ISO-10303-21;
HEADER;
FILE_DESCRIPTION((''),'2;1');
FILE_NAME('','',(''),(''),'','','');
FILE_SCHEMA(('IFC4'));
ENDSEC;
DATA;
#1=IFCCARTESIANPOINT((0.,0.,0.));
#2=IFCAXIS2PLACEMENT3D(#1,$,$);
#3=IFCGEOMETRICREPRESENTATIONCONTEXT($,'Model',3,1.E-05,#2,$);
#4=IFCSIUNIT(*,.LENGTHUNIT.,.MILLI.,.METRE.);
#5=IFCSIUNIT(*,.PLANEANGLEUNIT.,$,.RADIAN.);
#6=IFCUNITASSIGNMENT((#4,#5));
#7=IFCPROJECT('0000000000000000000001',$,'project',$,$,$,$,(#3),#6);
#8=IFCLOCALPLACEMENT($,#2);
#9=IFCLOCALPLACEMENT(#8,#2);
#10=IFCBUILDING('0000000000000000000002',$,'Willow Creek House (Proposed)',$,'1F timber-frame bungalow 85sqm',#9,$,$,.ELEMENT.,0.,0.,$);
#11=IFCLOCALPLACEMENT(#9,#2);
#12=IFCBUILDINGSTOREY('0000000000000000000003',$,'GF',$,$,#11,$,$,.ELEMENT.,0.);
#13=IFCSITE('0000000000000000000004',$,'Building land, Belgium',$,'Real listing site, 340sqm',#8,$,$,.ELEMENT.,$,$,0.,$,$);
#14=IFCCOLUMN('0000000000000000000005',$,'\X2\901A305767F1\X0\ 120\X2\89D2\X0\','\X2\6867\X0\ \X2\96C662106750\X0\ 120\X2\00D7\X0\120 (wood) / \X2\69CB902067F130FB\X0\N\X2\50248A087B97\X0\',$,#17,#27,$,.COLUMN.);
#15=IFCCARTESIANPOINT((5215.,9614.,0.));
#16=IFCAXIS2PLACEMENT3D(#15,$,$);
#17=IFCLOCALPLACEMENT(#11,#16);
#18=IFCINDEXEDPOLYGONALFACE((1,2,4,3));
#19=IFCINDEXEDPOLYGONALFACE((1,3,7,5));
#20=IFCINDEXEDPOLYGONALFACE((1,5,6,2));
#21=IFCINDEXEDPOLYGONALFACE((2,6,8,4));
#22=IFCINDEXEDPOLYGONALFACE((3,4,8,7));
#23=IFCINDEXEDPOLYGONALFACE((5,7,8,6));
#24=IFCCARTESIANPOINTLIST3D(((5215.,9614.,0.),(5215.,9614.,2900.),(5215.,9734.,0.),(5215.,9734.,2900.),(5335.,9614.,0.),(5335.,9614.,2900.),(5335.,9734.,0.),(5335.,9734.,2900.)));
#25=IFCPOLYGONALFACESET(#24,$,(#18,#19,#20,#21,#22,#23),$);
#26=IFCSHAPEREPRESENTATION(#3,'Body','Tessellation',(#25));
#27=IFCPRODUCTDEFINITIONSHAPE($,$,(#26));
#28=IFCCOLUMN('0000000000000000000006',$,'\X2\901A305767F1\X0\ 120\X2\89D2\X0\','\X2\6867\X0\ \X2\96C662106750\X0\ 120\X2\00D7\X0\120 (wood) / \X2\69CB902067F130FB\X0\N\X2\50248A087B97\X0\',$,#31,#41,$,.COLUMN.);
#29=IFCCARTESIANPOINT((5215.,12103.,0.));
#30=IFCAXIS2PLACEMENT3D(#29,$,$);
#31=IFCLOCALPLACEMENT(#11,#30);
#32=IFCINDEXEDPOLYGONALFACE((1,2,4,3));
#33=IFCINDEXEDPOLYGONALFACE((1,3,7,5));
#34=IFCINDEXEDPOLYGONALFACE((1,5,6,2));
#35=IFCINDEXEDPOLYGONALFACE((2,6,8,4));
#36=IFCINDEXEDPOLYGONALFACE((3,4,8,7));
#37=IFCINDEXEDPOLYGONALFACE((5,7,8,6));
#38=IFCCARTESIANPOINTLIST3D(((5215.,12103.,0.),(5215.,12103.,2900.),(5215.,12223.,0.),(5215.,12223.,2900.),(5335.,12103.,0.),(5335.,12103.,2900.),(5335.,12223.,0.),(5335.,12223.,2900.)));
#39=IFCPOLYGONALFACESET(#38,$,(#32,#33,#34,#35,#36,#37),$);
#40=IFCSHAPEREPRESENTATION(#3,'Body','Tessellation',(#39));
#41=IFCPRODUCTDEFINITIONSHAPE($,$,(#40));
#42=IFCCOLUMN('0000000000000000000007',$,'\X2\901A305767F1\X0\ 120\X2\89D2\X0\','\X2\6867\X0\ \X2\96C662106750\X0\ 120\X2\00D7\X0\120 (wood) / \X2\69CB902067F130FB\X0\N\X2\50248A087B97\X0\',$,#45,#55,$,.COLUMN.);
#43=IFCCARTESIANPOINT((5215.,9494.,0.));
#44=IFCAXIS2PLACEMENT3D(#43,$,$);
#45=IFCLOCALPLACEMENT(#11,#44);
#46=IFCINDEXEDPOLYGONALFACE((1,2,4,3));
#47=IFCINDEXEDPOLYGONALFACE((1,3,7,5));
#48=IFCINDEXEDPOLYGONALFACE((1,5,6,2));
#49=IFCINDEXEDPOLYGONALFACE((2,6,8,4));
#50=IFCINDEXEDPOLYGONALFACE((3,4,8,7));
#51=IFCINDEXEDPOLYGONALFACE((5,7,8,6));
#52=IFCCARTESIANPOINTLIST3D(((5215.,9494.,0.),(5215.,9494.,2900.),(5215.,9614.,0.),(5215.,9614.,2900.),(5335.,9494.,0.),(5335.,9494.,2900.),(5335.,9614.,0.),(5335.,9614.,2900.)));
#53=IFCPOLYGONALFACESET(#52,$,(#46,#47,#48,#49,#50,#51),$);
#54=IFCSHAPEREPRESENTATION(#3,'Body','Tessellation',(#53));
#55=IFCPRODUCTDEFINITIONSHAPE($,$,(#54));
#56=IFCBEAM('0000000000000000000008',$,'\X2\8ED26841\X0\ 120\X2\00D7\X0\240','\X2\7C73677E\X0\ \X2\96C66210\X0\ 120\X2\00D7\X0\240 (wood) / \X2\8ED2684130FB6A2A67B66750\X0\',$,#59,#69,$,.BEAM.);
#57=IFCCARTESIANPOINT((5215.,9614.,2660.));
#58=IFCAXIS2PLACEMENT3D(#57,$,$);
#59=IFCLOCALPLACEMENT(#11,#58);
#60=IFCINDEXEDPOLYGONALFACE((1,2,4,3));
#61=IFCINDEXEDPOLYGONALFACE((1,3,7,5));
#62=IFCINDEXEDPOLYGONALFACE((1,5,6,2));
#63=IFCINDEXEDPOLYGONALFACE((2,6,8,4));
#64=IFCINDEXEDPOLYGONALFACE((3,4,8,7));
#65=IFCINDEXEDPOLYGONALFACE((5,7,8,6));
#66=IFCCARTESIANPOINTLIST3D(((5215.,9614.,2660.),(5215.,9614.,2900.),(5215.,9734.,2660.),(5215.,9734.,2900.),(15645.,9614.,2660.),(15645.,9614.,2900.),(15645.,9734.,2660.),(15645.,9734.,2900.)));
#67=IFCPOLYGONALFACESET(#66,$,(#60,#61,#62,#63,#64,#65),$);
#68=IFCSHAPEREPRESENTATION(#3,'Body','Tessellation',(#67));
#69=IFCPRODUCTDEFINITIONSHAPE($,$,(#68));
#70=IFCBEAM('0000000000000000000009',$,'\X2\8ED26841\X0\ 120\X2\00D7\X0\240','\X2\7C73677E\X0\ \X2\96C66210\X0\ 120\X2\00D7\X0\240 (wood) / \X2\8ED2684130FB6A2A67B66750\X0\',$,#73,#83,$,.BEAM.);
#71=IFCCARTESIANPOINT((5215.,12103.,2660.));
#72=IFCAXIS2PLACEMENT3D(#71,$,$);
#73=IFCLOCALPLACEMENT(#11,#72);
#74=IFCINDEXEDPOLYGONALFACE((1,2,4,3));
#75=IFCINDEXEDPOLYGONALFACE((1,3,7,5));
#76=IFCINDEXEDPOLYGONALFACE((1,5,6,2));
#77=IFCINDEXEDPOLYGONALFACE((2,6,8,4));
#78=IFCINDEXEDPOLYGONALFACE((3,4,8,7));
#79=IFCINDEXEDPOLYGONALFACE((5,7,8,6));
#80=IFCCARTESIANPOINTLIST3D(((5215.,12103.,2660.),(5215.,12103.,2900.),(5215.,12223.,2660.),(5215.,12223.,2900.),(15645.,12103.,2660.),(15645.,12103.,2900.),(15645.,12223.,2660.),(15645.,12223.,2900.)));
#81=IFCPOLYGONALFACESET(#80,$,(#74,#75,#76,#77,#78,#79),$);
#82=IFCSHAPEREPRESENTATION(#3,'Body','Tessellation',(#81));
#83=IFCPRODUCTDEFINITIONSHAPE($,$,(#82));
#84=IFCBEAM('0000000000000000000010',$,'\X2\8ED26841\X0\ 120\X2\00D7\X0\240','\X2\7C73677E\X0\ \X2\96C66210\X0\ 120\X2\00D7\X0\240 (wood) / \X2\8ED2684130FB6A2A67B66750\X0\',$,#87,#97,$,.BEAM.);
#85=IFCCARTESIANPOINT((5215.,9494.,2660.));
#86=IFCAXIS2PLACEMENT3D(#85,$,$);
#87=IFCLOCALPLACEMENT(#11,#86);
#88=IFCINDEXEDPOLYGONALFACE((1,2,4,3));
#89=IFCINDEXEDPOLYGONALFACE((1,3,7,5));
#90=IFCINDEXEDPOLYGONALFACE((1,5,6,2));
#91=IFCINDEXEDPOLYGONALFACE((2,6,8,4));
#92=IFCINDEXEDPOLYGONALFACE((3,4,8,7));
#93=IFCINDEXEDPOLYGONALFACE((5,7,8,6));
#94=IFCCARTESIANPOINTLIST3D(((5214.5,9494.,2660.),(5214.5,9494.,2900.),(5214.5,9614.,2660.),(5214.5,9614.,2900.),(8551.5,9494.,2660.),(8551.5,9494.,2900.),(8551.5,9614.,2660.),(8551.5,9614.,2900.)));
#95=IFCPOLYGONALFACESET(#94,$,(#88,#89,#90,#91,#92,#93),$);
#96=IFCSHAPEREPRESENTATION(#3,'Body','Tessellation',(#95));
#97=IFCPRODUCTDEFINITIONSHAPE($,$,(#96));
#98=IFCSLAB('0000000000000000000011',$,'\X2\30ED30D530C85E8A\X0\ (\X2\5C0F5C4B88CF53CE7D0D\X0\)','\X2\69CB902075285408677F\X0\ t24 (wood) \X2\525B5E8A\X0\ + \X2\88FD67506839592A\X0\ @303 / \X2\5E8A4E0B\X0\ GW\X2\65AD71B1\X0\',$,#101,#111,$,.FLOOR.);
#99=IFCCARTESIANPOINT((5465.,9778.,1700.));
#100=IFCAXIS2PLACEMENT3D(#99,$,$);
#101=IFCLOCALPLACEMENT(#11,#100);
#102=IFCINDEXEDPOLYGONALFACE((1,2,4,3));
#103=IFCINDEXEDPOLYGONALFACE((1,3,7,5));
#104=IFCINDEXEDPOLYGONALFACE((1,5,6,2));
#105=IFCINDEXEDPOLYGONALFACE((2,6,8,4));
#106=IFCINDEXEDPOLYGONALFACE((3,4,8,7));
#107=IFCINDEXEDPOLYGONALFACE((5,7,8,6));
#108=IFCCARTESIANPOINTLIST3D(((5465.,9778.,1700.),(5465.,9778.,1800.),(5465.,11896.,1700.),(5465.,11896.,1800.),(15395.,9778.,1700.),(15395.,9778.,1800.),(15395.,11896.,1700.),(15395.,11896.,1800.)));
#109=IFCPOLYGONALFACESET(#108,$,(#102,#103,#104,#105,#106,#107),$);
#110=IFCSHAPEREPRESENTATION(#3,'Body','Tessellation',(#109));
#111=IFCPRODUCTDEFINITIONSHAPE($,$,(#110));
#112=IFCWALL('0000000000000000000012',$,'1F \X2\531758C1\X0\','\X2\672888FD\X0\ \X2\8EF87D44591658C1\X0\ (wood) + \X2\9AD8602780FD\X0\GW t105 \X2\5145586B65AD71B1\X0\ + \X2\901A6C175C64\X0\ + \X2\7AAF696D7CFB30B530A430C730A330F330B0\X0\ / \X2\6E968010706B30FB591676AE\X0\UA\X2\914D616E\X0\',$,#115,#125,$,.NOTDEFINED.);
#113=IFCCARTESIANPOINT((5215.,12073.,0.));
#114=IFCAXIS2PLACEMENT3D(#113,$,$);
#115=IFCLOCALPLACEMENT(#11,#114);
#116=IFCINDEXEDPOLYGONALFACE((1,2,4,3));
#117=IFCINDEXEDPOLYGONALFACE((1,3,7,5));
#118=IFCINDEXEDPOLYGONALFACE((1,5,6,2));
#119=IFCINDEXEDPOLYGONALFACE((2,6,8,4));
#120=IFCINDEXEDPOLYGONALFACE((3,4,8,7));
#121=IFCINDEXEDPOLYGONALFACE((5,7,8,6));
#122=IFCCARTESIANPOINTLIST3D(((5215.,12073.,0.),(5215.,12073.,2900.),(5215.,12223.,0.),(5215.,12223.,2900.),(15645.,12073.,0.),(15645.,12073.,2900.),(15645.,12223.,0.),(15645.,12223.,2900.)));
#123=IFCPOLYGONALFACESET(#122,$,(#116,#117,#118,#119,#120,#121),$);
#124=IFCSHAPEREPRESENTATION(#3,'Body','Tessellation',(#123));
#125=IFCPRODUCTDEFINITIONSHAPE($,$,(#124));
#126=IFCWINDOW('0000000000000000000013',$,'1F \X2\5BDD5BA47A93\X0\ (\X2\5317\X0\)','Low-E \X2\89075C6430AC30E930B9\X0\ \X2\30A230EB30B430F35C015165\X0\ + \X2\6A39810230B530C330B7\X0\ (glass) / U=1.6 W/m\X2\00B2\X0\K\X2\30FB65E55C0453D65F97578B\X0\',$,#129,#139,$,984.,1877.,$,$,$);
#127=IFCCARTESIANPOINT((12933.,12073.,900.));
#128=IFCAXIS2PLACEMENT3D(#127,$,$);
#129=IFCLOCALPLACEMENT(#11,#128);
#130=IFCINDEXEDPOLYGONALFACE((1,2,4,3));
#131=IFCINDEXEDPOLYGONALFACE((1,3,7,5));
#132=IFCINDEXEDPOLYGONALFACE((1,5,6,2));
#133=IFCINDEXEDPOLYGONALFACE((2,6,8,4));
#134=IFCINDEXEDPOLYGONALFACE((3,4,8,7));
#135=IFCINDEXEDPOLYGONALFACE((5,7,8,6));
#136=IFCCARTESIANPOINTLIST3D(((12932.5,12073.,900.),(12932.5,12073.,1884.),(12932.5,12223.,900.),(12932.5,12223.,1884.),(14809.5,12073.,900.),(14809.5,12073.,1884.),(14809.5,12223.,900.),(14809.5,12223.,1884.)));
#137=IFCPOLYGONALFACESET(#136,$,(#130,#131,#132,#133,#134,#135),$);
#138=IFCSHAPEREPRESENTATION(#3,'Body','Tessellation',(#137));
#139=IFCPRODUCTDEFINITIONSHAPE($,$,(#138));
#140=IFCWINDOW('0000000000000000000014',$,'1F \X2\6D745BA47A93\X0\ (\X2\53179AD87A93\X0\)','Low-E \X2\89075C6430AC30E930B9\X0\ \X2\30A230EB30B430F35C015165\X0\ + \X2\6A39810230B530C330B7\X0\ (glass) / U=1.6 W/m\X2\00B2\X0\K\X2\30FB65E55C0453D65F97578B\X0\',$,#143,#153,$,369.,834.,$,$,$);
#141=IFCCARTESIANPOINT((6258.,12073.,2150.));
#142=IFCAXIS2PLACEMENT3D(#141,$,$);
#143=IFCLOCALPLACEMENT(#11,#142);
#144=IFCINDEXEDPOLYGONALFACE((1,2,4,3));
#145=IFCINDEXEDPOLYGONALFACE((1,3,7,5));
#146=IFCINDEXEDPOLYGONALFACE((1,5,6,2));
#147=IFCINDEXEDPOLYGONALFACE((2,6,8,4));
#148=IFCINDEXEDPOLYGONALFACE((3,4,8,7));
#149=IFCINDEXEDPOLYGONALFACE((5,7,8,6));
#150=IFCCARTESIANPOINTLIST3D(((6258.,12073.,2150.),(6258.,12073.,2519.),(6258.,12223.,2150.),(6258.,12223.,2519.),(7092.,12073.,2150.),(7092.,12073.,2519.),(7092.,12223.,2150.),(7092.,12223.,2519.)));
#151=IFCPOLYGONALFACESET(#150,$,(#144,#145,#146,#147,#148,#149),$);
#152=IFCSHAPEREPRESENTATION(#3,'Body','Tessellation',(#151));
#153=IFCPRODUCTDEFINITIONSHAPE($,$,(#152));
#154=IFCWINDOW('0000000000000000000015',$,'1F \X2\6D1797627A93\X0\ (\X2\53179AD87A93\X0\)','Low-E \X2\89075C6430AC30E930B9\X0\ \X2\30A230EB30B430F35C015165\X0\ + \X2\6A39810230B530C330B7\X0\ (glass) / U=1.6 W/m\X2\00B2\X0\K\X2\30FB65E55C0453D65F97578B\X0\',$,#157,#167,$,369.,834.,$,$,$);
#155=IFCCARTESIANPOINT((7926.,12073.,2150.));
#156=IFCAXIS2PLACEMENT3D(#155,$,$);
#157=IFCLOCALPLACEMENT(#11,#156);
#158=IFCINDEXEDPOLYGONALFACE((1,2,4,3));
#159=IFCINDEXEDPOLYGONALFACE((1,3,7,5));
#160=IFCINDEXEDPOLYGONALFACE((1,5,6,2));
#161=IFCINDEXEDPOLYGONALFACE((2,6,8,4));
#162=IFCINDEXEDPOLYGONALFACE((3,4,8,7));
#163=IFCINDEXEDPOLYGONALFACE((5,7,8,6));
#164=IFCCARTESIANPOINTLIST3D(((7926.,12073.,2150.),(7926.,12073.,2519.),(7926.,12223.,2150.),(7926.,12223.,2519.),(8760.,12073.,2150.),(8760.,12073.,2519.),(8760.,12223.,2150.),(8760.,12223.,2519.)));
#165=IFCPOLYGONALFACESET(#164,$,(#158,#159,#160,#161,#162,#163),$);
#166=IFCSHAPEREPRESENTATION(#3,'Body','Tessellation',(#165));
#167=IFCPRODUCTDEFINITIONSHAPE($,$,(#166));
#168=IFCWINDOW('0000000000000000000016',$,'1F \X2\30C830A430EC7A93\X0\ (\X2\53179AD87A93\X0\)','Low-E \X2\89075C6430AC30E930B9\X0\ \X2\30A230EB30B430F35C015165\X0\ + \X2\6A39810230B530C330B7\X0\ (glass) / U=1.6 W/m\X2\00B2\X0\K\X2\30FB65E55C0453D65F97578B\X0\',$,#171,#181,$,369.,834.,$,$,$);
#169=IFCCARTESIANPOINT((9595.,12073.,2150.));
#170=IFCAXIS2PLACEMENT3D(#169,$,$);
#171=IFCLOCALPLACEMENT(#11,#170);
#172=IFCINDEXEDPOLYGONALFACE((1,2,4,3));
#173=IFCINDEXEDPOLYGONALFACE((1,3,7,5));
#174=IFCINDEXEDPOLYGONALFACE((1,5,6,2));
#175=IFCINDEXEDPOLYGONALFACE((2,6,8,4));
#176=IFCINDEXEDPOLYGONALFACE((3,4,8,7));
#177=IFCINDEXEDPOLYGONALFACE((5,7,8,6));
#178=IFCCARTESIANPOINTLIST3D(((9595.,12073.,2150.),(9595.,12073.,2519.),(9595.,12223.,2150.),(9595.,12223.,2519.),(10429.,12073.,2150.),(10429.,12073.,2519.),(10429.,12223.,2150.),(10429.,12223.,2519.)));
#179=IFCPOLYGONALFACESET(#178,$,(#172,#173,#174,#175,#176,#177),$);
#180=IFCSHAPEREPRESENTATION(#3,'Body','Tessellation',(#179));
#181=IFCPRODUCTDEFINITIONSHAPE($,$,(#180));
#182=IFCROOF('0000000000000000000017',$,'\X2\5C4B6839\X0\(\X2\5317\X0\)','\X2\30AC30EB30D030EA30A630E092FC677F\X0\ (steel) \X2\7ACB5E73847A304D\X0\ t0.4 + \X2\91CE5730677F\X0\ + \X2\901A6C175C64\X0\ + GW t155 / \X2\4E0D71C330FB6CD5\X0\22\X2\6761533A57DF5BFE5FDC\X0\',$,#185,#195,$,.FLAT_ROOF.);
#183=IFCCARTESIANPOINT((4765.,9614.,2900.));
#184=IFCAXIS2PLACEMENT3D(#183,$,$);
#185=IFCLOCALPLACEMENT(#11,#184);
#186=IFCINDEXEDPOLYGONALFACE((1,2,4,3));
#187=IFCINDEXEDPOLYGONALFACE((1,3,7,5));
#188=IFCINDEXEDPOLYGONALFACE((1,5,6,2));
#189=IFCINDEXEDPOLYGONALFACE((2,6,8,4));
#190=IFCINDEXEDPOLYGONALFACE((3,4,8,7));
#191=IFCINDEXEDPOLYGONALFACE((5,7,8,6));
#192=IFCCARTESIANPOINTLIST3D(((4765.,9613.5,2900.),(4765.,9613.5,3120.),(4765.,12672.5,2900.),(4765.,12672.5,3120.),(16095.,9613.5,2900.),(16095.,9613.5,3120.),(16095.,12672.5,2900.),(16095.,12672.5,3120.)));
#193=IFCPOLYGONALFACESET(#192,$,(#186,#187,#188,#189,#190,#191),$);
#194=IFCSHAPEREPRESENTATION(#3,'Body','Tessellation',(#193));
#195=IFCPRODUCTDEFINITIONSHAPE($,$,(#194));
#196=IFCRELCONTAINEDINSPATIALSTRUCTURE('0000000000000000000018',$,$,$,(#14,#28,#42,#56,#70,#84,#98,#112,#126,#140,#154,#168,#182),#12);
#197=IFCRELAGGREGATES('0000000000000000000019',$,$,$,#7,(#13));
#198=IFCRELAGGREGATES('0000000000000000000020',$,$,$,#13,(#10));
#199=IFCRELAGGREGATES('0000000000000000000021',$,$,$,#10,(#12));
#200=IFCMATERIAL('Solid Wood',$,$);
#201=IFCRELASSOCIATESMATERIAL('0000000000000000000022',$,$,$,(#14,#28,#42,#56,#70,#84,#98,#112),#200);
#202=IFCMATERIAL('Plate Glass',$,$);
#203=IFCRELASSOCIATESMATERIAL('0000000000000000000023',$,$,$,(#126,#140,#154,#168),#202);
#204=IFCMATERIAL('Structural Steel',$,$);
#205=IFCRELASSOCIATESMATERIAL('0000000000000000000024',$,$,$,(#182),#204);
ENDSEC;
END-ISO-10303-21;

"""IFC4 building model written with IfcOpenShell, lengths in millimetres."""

from ifc_helpers import new_model, si_unit, frame, frame_2d, origin, place, context, project, spatial, rectangle, extrude, material, element, fill, save


model = new_model("IFC4")

# Units and contexts
model_context = context("Model", 3, precision=1e-05, world=origin())
ifc_project = project(units=[si_unit("LENGTHUNIT", "METRE", prefix="MILLI"), si_unit("PLANEANGLEUNIT", "RADIAN")], contexts=[model_context])

# Site, building, storey
site_placement = place(None, origin())
site = spatial("IfcSite", under=ifc_project, at=site_placement, Name="Building land, Belgium", ObjectType="Real listing site, 340sqm", CompositionType="ELEMENT", RefElevation=0.0)
building_placement = place(site_placement, origin())
building = spatial("IfcBuilding", under=site, at=building_placement, Name="Willow Creek House (Proposed)", ObjectType="1F timber-frame bungalow 85sqm", CompositionType="ELEMENT", ElevationOfRefHeight=0.0, ElevationOfTerrain=0.0)
storey_placement = place(building_placement, origin())
storey = spatial("IfcBuildingStorey", under=building, at=storey_placement, Name="GF", CompositionType="ELEMENT", Elevation=0.0)

# Columns
ifc_material_1 = material(Name="Solid Wood")
column_1_placement = place(storey_placement, frame((5215.0, 9614.0, 0.0)))
element("IfcColumn", 1, at=column_1_placement, inside=storey, material=ifc_material_1, Name="通し柱 120角", Description="桧 集成材 120×120 (wood) / 構造柱・N値計算", PredefinedType="COLUMN", context=model_context, shape_type="SweptSolid", body=[
    extrude(rectangle(XDim=120.0, YDim=120.0, at=frame_2d((60.0, 60.0))), frame((5215.0, 9614.0, 0.0)), (0.0, 0.0, 1.0), 2900.0),
])
column_2_placement = place(storey_placement, frame((5215.0, 12103.0, 0.0)))
element("IfcColumn", 2, at=column_2_placement, inside=storey, material=ifc_material_1, Name="通し柱 120角", Description="桧 集成材 120×120 (wood) / 構造柱・N値計算", PredefinedType="COLUMN", context=model_context, shape_type="SweptSolid", body=[
    extrude(rectangle(XDim=120.0, YDim=120.0, at=frame_2d((60.0, 60.0))), frame((5215.0, 12103.0, 0.0)), (0.0, 0.0, 1.0), 2900.0),
])
column_3_placement = place(storey_placement, frame((5215.0, 9494.0, 0.0)))
element("IfcColumn", 3, at=column_3_placement, inside=storey, material=ifc_material_1, Name="通し柱 120角", Description="桧 集成材 120×120 (wood) / 構造柱・N値計算", PredefinedType="COLUMN", context=model_context, shape_type="SweptSolid", body=[
    extrude(rectangle(XDim=120.0, YDim=120.0, at=frame_2d((60.0, 60.0))), frame((5215.0, 9494.0, 0.0)), (0.0, 0.0, 1.0), 2900.0),
])

# Beams
beam_1_placement = place(storey_placement, frame((5215.0, 9614.0, 2660.0)))
element("IfcBeam", 4, at=beam_1_placement, inside=storey, material=ifc_material_1, Name="軒桁 120×240", Description="米松 集成 120×240 (wood) / 軒桁・横架材", PredefinedType="BEAM", context=model_context, shape_type="SweptSolid", body=[
    extrude(rectangle(XDim=10430.0, YDim=120.0, at=frame_2d((5215.0, 60.0))), frame((5215.0, 9614.0, 2660.0)), (0.0, 0.0, 1.0), 240.0),
])
beam_2_placement = place(storey_placement, frame((5215.0, 12103.0, 2660.0)))
element("IfcBeam", 5, at=beam_2_placement, inside=storey, material=ifc_material_1, Name="軒桁 120×240", Description="米松 集成 120×240 (wood) / 軒桁・横架材", PredefinedType="BEAM", context=model_context, shape_type="SweptSolid", body=[
    extrude(rectangle(XDim=10430.0, YDim=120.0, at=frame_2d((5215.0, 60.0))), frame((5215.0, 12103.0, 2660.0)), (0.0, 0.0, 1.0), 240.0),
])
beam_3_placement = place(storey_placement, frame((5215.0, 9494.0, 2660.0)))
element("IfcBeam", 6, at=beam_3_placement, inside=storey, material=ifc_material_1, Name="軒桁 120×240", Description="米松 集成 120×240 (wood) / 軒桁・横架材", PredefinedType="BEAM", context=model_context, shape_type="SweptSolid", body=[
    extrude(rectangle(XDim=3337.0, YDim=120.0, at=frame_2d((1668.0, 60.0))), frame((5215.0, 9494.0, 2660.0)), (0.0, 0.0, 1.0), 240.0),
])

# Slab
slab_1_placement = place(storey_placement, frame((5465.0, 9778.0, 1700.0)))
element("IfcSlab", 7, at=slab_1_placement, inside=storey, material=ifc_material_1, Name="ロフト床 (小屋裏収納)", Description="構造用合板 t24 (wood) 剛床 + 製材根太 @303 / 床下 GW断熱", PredefinedType="FLOOR", context=model_context, shape_type="SweptSolid", body=[
    extrude(rectangle(XDim=9930.0, YDim=2118.0, at=frame_2d((4965.0, 1059.0))), frame((5465.0, 9778.0, 1700.0)), (0.0, 0.0, 1.0), 100.0),
])

# Wall, openings, windows
wall_1_placement = place(storey_placement, frame((5215.0, 12073.0, 0.0)))
wall_1 = element("IfcWall", 8, at=wall_1_placement, inside=storey, material=ifc_material_1, Name="1F 北壁", Description="木製 軸組外壁 (wood) + 高性能GW t105 充填断熱 + 通気層 + 窯業系サイディング / 準耐火・外皮UA配慮", PredefinedType="NOTDEFINED", context=model_context, shape_type="SweptSolid", body=[
    extrude(rectangle(XDim=10430.0, YDim=150.0, at=frame_2d((5215.0, 75.0))), frame((5215.0, 12073.0, 0.0)), (0.0, 0.0, 1.0), 2900.0),
])
opening_1_placement = place(storey_placement, frame((12933.0, 12073.0, 900.0)))
opening_1 = element("IfcOpeningElement", 9, at=opening_1_placement, cuts=wall_1, PredefinedType="NOTDEFINED", context=model_context, shape_type="SweptSolid", body=[
    extrude(rectangle(XDim=1877.0, YDim=150.0, at=frame_2d((938.0, 75.0))), frame((12933.0, 12073.0, 900.0)), (0.0, 0.0, 1.0), 984.0),
])
opening_2_placement = place(storey_placement, frame((6258.0, 12073.0, 2150.0)))
opening_2 = element("IfcOpeningElement", 10, at=opening_2_placement, cuts=wall_1, PredefinedType="NOTDEFINED", context=model_context, shape_type="SweptSolid", body=[
    extrude(rectangle(XDim=834.0, YDim=150.0, at=frame_2d((417.0, 75.0))), frame((6258.0, 12073.0, 2150.0)), (0.0, 0.0, 1.0), 369.0),
])
opening_3_placement = place(storey_placement, frame((7926.0, 12073.0, 2150.0)))
opening_3 = element("IfcOpeningElement", 11, at=opening_3_placement, cuts=wall_1, PredefinedType="NOTDEFINED", context=model_context, shape_type="SweptSolid", body=[
    extrude(rectangle(XDim=834.0, YDim=150.0, at=frame_2d((417.0, 75.0))), frame((7926.0, 12073.0, 2150.0)), (0.0, 0.0, 1.0), 369.0),
])
opening_4_placement = place(storey_placement, frame((9595.0, 12073.0, 2150.0)))
opening_4 = element("IfcOpeningElement", 12, at=opening_4_placement, cuts=wall_1, PredefinedType="NOTDEFINED", context=model_context, shape_type="SweptSolid", body=[
    extrude(rectangle(XDim=834.0, YDim=150.0, at=frame_2d((417.0, 75.0))), frame((9595.0, 12073.0, 2150.0)), (0.0, 0.0, 1.0), 369.0),
])
ifc_material_2 = material(Name="Plate Glass")
window_1_placement = place(storey_placement, frame((12933.0, 12073.0, 900.0)))
window_1 = element("IfcWindow", 13, at=window_1_placement, inside=storey, material=ifc_material_2, Name="1F 寝室窓 (北)", Description="Low-E 複層ガラス アルゴン封入 + 樹脂サッシ (glass) / U=1.6 W/m²K・日射取得型", OverallHeight=984.0, OverallWidth=1877.0, context=model_context, shape_type="SweptSolid", body=[
    extrude(rectangle(XDim=1877.0, YDim=150.0, at=frame_2d((938.0, 75.0))), frame((12933.0, 12073.0, 900.0)), (0.0, 0.0, 1.0), 984.0),
])
fill(opening_1, window_1)
window_2_placement = place(storey_placement, frame((6258.0, 12073.0, 2150.0)))
window_2 = element("IfcWindow", 14, at=window_2_placement, inside=storey, material=ifc_material_2, Name="1F 浴室窓 (北高窓)", Description="Low-E 複層ガラス アルゴン封入 + 樹脂サッシ (glass) / U=1.6 W/m²K・日射取得型", OverallHeight=369.0, OverallWidth=834.0, context=model_context, shape_type="SweptSolid", body=[
    extrude(rectangle(XDim=834.0, YDim=150.0, at=frame_2d((417.0, 75.0))), frame((6258.0, 12073.0, 2150.0)), (0.0, 0.0, 1.0), 369.0),
])
fill(opening_2, window_2)
window_3_placement = place(storey_placement, frame((7926.0, 12073.0, 2150.0)))
window_3 = element("IfcWindow", 15, at=window_3_placement, inside=storey, material=ifc_material_2, Name="1F 洗面窓 (北高窓)", Description="Low-E 複層ガラス アルゴン封入 + 樹脂サッシ (glass) / U=1.6 W/m²K・日射取得型", OverallHeight=369.0, OverallWidth=834.0, context=model_context, shape_type="SweptSolid", body=[
    extrude(rectangle(XDim=834.0, YDim=150.0, at=frame_2d((417.0, 75.0))), frame((7926.0, 12073.0, 2150.0)), (0.0, 0.0, 1.0), 369.0),
])
fill(opening_3, window_3)
window_4_placement = place(storey_placement, frame((9595.0, 12073.0, 2150.0)))
window_4 = element("IfcWindow", 16, at=window_4_placement, inside=storey, material=ifc_material_2, Name="1F トイレ窓 (北高窓)", Description="Low-E 複層ガラス アルゴン封入 + 樹脂サッシ (glass) / U=1.6 W/m²K・日射取得型", OverallHeight=369.0, OverallWidth=834.0, context=model_context, shape_type="SweptSolid", body=[
    extrude(rectangle(XDim=834.0, YDim=150.0, at=frame_2d((417.0, 75.0))), frame((9595.0, 12073.0, 2150.0)), (0.0, 0.0, 1.0), 369.0),
])
fill(opening_4, window_4)

# Roof
ifc_material_3 = material(Name="Structural Steel")
roof_placement = place(storey_placement, frame((4765.0, 9614.0, 2900.0)))
element("IfcRoof", 17, at=roof_placement, inside=storey, material=ifc_material_3, Name="屋根(北)", Description="ガルバリウム鋼板 (steel) 立平葺き t0.4 + 野地板 + 通気層 + GW t155 / 不燃・法22条区域対応", PredefinedType="FLAT_ROOF", context=model_context, shape_type="SweptSolid", body=[
    extrude(rectangle(XDim=11330.0, YDim=3059.0, at=frame_2d((5665.0, 1529.0))), frame((4765.0, 9614.0, 2900.0)), (0.0, 0.0, 1.0), 220.0),
])

save(model, "model.ifc")
